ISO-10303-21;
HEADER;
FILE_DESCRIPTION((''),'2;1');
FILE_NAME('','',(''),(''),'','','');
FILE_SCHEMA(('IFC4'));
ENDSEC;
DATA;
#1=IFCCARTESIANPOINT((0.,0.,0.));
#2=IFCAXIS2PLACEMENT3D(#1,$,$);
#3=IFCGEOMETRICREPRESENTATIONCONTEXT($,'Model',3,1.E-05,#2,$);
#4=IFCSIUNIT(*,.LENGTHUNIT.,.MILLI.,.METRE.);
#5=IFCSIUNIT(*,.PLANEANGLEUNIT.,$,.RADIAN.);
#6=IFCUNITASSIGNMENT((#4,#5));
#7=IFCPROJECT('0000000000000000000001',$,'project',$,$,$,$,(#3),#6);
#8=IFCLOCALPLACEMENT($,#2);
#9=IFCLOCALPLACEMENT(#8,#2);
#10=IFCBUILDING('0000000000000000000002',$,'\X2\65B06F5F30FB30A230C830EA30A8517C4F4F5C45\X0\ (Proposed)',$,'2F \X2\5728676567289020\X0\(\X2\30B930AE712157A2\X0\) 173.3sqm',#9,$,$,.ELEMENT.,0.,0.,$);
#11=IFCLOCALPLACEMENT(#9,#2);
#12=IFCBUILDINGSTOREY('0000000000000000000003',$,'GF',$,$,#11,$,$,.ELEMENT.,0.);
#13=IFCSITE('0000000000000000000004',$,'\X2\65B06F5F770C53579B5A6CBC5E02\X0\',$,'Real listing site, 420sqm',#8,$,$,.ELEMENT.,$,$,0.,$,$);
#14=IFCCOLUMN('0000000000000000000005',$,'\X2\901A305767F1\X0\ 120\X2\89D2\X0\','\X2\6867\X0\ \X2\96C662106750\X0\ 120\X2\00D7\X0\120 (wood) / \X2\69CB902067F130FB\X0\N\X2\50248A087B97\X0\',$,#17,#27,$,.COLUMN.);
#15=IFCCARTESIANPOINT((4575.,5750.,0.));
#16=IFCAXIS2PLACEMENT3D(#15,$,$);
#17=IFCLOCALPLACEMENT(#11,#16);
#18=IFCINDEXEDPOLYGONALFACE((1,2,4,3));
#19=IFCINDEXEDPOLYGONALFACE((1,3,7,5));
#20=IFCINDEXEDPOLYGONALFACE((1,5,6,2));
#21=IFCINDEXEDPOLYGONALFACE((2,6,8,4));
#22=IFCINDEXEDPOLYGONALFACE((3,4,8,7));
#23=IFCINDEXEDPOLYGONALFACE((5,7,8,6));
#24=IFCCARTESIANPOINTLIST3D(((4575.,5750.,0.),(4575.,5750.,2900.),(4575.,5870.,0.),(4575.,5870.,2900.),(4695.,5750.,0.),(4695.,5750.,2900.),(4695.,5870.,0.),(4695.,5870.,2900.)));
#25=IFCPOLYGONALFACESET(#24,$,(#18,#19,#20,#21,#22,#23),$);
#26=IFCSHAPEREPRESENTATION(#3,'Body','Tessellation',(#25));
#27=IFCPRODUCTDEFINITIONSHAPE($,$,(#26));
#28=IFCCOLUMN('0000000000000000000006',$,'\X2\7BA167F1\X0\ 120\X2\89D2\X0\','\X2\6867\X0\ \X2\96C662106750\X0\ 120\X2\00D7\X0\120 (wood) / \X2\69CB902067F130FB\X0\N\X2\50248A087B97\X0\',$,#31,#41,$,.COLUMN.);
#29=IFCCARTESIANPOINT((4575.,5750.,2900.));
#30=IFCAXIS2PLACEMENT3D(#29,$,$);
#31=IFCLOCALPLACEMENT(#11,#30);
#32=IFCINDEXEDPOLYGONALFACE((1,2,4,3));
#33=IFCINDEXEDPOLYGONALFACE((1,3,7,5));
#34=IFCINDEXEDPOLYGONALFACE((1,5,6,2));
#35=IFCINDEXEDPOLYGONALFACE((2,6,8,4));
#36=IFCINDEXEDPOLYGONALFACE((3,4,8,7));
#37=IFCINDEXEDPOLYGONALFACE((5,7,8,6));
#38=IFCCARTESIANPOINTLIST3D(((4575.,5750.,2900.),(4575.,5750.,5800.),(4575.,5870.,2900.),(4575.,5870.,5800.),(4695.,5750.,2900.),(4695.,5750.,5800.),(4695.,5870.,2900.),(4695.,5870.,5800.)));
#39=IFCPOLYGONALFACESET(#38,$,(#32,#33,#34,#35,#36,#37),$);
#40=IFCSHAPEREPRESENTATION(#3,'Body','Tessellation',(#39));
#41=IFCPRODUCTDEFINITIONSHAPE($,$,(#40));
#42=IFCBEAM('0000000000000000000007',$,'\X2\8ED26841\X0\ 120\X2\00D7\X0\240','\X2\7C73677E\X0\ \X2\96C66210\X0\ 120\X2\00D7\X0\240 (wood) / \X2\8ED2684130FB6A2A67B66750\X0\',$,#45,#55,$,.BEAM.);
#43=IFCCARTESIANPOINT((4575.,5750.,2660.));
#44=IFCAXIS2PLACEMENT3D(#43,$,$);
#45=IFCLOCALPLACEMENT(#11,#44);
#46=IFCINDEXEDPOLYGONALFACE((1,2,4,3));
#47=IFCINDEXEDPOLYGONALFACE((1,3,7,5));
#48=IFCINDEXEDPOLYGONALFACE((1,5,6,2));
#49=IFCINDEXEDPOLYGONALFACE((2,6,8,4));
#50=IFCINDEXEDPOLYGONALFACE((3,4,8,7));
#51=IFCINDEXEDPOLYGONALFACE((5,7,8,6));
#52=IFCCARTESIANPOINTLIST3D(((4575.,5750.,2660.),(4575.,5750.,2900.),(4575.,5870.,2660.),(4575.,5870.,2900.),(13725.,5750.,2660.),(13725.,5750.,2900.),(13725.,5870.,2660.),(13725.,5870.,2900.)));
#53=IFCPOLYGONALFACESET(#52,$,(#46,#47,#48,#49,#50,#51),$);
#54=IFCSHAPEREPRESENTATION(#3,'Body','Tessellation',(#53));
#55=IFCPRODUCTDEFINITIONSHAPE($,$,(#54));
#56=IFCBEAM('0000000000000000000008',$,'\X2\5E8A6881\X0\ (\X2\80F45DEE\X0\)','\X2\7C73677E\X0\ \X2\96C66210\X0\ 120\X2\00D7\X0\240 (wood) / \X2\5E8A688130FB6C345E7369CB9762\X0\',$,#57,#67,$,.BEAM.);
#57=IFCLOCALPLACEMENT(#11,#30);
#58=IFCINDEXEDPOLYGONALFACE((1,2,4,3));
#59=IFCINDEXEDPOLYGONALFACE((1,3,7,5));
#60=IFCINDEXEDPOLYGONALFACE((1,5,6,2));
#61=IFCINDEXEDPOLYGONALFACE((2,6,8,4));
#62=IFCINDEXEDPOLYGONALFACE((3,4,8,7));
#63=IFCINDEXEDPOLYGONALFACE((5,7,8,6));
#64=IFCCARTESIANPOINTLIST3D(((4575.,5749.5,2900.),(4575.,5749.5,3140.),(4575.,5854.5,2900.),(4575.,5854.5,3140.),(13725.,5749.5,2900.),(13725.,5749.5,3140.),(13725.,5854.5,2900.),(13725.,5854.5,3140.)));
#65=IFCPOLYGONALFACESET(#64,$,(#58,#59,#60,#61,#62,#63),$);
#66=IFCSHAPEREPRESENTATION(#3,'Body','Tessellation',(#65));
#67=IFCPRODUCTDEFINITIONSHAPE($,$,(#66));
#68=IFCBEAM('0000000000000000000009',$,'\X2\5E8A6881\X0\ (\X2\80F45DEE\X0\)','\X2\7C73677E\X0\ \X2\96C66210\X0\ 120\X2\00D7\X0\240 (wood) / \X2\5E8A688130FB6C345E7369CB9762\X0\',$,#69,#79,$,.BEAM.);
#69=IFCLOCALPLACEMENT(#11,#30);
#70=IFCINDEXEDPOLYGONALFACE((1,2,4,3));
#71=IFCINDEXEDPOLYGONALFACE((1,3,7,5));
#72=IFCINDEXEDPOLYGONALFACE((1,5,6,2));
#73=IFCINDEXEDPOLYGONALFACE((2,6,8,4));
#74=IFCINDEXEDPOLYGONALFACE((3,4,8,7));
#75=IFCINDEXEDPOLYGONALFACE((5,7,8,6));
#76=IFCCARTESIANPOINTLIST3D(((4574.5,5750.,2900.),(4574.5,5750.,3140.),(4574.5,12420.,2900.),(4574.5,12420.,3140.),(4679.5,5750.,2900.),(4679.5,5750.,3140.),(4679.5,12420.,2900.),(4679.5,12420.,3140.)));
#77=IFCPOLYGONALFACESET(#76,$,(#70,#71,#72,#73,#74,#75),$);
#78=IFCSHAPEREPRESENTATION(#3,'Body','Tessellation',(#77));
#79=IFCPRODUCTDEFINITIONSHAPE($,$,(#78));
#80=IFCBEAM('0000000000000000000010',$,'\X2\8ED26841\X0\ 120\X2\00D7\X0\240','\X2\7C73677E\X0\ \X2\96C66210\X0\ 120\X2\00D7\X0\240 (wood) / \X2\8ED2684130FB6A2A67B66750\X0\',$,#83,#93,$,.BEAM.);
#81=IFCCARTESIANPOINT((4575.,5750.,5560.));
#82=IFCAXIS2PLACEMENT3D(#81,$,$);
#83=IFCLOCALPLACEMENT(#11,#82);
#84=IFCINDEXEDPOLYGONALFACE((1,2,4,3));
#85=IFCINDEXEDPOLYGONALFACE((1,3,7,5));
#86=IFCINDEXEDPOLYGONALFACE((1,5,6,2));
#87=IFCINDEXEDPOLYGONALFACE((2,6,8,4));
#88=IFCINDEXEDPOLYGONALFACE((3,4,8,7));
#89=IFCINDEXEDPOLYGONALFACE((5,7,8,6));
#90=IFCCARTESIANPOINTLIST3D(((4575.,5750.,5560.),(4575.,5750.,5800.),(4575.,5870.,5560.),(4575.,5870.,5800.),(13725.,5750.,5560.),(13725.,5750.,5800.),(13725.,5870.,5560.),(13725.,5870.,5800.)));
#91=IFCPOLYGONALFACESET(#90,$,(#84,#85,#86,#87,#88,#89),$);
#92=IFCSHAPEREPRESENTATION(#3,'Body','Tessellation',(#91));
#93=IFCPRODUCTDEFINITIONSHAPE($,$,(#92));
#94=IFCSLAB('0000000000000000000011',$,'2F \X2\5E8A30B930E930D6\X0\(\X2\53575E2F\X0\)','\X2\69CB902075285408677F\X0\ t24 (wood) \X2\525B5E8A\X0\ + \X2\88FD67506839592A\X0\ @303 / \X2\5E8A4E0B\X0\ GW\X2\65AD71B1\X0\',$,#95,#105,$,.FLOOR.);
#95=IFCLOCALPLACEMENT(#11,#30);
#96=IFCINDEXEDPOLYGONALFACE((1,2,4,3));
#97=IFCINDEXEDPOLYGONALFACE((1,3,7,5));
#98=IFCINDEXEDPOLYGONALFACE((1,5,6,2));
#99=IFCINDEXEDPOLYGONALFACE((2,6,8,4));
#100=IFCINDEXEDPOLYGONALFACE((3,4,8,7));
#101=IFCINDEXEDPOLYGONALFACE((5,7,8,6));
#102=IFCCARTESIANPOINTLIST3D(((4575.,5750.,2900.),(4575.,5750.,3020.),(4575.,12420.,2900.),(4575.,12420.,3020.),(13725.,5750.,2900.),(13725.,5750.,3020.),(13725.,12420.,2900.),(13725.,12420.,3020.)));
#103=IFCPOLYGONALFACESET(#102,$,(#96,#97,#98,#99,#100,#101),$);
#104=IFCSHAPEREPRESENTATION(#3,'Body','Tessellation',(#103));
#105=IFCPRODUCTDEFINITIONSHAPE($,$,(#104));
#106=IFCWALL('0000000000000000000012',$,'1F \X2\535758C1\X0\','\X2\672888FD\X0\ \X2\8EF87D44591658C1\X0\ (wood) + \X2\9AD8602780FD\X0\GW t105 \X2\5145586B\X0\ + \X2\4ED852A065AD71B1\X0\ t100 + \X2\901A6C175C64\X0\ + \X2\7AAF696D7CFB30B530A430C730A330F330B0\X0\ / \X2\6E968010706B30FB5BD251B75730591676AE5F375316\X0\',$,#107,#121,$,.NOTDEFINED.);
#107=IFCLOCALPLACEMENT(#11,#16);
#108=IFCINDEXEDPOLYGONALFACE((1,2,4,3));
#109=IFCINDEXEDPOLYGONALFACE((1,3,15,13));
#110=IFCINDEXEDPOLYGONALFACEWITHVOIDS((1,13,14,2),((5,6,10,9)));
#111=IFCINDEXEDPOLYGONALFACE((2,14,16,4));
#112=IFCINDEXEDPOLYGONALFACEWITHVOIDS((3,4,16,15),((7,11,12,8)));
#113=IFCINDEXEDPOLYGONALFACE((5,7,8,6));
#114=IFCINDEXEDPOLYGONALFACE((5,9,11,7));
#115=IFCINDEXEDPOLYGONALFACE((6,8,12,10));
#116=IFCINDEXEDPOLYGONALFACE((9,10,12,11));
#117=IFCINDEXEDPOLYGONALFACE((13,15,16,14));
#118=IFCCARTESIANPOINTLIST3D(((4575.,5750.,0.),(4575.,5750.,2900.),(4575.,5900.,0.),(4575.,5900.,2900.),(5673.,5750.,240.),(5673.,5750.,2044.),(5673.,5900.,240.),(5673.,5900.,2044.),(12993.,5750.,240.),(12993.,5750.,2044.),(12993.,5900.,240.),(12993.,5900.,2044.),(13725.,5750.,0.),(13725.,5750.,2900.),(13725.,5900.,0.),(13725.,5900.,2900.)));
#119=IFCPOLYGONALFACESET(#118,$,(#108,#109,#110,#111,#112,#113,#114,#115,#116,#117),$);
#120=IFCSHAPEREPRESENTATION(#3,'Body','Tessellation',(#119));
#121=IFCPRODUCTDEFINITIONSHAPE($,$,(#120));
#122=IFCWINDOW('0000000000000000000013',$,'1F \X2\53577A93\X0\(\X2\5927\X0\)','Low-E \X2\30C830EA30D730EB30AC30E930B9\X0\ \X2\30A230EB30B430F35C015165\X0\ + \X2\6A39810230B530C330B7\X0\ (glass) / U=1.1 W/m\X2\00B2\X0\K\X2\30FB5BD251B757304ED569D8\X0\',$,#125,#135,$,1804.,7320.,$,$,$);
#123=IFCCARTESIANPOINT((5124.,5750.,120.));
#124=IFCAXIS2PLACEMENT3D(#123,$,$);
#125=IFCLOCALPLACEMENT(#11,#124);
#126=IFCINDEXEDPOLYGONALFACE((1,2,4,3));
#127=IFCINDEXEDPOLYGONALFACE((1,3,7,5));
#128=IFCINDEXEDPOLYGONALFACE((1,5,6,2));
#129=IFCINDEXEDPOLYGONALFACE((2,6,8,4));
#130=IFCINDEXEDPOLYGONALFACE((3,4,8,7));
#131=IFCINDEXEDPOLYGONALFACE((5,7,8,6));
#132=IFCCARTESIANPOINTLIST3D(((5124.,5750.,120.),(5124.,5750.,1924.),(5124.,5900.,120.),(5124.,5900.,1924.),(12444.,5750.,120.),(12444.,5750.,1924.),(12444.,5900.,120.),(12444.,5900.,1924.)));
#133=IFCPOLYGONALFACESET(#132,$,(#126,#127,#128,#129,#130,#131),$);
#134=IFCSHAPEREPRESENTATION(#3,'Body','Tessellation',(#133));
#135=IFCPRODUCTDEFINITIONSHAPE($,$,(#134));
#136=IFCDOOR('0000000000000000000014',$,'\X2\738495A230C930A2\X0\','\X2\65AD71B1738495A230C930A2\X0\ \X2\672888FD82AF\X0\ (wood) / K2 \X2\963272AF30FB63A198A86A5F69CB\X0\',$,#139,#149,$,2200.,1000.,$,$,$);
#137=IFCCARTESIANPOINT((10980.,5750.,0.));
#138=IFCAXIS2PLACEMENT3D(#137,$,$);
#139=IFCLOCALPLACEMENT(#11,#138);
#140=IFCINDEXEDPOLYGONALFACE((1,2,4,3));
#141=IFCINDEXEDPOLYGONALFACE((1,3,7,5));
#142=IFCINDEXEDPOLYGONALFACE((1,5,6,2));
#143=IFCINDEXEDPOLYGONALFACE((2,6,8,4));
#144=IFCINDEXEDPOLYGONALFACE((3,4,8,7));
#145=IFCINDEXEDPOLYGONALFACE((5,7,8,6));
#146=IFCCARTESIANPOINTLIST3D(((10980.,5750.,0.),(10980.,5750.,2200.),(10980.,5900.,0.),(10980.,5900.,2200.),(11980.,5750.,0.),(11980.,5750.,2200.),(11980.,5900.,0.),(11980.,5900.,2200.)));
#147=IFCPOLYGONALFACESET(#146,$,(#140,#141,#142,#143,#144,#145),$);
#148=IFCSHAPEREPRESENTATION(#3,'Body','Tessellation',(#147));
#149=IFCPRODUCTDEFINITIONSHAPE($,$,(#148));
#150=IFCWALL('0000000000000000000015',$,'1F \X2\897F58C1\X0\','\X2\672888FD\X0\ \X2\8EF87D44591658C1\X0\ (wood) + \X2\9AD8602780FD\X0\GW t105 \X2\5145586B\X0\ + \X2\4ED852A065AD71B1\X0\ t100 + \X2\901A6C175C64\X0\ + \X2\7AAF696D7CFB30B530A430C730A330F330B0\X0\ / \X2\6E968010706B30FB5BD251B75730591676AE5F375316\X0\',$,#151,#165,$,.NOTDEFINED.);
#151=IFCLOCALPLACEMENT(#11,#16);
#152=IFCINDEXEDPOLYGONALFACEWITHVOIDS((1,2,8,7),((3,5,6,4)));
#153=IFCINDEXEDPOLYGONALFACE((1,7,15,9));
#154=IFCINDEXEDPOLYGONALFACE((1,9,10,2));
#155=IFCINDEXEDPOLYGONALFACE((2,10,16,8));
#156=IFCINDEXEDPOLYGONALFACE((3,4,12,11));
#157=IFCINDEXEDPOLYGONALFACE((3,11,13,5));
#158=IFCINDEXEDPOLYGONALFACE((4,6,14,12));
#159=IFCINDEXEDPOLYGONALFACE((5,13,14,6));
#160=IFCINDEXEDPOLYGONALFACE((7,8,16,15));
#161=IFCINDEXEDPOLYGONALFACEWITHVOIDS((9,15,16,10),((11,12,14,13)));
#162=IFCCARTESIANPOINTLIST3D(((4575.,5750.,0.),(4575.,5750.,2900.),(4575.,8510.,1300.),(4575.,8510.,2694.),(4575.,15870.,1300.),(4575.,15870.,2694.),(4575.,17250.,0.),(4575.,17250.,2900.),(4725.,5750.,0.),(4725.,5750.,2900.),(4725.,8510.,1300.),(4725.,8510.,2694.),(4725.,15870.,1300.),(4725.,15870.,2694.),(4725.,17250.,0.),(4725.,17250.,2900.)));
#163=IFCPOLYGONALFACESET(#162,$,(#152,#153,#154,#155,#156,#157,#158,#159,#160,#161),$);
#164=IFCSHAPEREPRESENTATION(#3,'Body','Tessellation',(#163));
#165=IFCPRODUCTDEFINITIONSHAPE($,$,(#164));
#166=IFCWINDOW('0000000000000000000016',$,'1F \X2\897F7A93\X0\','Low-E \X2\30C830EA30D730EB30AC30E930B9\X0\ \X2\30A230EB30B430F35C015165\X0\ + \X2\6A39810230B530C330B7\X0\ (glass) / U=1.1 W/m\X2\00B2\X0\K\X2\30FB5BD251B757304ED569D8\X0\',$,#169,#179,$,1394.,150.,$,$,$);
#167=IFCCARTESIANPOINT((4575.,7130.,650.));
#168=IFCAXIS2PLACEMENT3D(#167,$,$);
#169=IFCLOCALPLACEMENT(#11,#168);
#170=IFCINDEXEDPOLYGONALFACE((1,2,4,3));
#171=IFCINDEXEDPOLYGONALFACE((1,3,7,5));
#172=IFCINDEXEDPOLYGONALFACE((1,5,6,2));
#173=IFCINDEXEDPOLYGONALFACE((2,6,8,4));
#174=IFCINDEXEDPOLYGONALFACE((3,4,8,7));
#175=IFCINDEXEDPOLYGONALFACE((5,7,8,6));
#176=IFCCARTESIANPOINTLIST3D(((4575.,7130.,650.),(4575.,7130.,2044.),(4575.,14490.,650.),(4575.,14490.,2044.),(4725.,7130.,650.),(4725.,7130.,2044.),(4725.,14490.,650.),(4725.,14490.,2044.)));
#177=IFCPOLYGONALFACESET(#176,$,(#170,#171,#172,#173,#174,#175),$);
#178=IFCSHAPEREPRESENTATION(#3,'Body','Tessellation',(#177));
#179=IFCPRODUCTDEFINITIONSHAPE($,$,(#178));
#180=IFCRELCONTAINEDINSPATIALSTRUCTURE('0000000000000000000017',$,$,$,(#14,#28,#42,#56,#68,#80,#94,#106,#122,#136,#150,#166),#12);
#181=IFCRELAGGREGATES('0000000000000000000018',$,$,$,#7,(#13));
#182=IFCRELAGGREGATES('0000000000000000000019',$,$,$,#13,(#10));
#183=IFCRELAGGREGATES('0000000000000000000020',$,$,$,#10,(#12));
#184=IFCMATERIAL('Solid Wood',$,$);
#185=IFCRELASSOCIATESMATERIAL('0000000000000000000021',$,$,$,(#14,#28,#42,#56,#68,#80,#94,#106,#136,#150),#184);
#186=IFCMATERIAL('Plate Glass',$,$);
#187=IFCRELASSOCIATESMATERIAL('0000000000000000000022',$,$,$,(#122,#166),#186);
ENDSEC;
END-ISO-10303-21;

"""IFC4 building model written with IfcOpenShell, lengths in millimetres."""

from ifc_helpers import new_model, si_unit, frame, frame_2d, origin, place, context, project, spatial, rectangle, extrude, material, element, fill, save


model = new_model("IFC4")

# Units and contexts
model_context = context("Model", 3, precision=1e-05, world=origin())
ifc_project = project(units=[si_unit("LENGTHUNIT", "METRE", prefix="MILLI"), si_unit("PLANEANGLEUNIT", "RADIAN")], contexts=[model_context])

# Site, building, storey
site_placement = place(None, origin())
site = spatial("IfcSite", under=ifc_project, at=site_placement, Name="新潟県南魚沼市", ObjectType="Real listing site, 420sqm", CompositionType="ELEMENT", RefElevation=0.0)
building_placement = place(site_placement, origin())
building = spatial("IfcBuilding", under=site, at=building_placement, Name="新潟・アトリエ兼住居 (Proposed)", ObjectType="2F 在来木造(スギ無垢) 173.3sqm", CompositionType="ELEMENT", ElevationOfRefHeight=0.0, ElevationOfTerrain=0.0)
storey_placement = place(building_placement, origin())
storey = spatial("IfcBuildingStorey", under=building, at=storey_placement, Name="GF", CompositionType="ELEMENT", Elevation=0.0)

# Columns
ifc_material_1 = material(Name="Solid Wood")
column_1_placement = place(storey_placement, frame((4575.0, 5750.0, 0.0)))
element("IfcColumn", 1, at=column_1_placement, inside=storey, material=ifc_material_1, Name="通し柱 120角", Description="桧 集成材 120×120 (wood) / 構造柱・N値計算", PredefinedType="COLUMN", context=model_context, shape_type="SweptSolid", body=[
    extrude(rectangle(XDim=120.0, YDim=120.0, at=frame_2d((60.0, 60.0))), frame((4575.0, 5750.0, 0.0)), (0.0, 0.0, 1.0), 2900.0),
])
column_2_placement = place(storey_placement, frame((4575.0, 5750.0, 2900.0)))
element("IfcColumn", 2, at=column_2_placement, inside=storey, material=ifc_material_1, Name="管柱 120角", Description="桧 集成材 120×120 (wood) / 構造柱・N値計算", PredefinedType="COLUMN", context=model_context, shape_type="SweptSolid", body=[
    extrude(rectangle(XDim=120.0, YDim=120.0, at=frame_2d((60.0, 60.0))), frame((4575.0, 5750.0, 2900.0)), (0.0, 0.0, 1.0), 2900.0),
])

# Beams
beam_1_placement = place(storey_placement, frame((4575.0, 5750.0, 2660.0)))
element("IfcBeam", 3, at=beam_1_placement, inside=storey, material=ifc_material_1, Name="軒桁 120×240", Description="米松 集成 120×240 (wood) / 軒桁・横架材", PredefinedType="BEAM", context=model_context, shape_type="SweptSolid", body=[
    extrude(rectangle(XDim=9150.0, YDim=120.0, at=frame_2d((4575.0, 60.0))), frame((4575.0, 5750.0, 2660.0)), (0.0, 0.0, 1.0), 240.0),
])
beam_2_placement = place(storey_placement, frame((4575.0, 5750.0, 2900.0)))
element("IfcBeam", 4, at=beam_2_placement, inside=storey, material=ifc_material_1, Name="床梁 (胴差)", Description="米松 集成 120×240 (wood) / 床梁・水平構面", PredefinedType="BEAM", context=model_context, shape_type="SweptSolid", body=[
    extrude(rectangle(XDim=9150.0, YDim=105.0, at=frame_2d((4575.0, 52.0))), frame((4575.0, 5750.0, 2900.0)), (0.0, 0.0, 1.0), 240.0),
])
beam_3_placement = place(storey_placement, frame((4575.0, 5750.0, 2900.0)))
element("IfcBeam", 5, at=beam_3_placement, inside=storey, material=ifc_material_1, Name="床梁 (胴差)", Description="米松 集成 120×240 (wood) / 床梁・水平構面", PredefinedType="BEAM", context=model_context, shape_type="SweptSolid", body=[
    extrude(rectangle(XDim=105.0, YDim=6670.0, at=frame_2d((52.0, 3335.0))), frame((4575.0, 5750.0, 2900.0)), (0.0, 0.0, 1.0), 240.0),
])
beam_4_placement = place(storey_placement, frame((4575.0, 5750.0, 5560.0)))
element("IfcBeam", 6, at=beam_4_placement, inside=storey, material=ifc_material_1, Name="軒桁 120×240", Description="米松 集成 120×240 (wood) / 軒桁・横架材", PredefinedType="BEAM", context=model_context, shape_type="SweptSolid", body=[
    extrude(rectangle(XDim=9150.0, YDim=120.0, at=frame_2d((4575.0, 60.0))), frame((4575.0, 5750.0, 5560.0)), (0.0, 0.0, 1.0), 240.0),
])

# Slab
slab_1_placement = place(storey_placement, frame((4575.0, 5750.0, 2900.0)))
element("IfcSlab", 7, at=slab_1_placement, inside=storey, material=ifc_material_1, Name="2F 床スラブ(南帯)", Description="構造用合板 t24 (wood) 剛床 + 製材根太 @303 / 床下 GW断熱", PredefinedType="FLOOR", context=model_context, shape_type="SweptSolid", body=[
    extrude(rectangle(XDim=9150.0, YDim=6670.0, at=frame_2d((4575.0, 3335.0))), frame((4575.0, 5750.0, 2900.0)), (0.0, 0.0, 1.0), 120.0),
])

# Wall, openings, window, door
wall_1_placement = place(storey_placement, frame((4575.0, 5750.0, 0.0)))
wall_1 = element("IfcWall", 8, at=wall_1_placement, inside=storey, material=ifc_material_1, Name="1F 南壁", Description="木製 軸組外壁 (wood) + 高性能GW t105 充填 + 付加断熱 t100 + 通気層 + 窯業系サイディング / 準耐火・寒冷地外皮強化", PredefinedType="NOTDEFINED", context=model_context, shape_type="SweptSolid", body=[
    extrude(rectangle(XDim=9150.0, YDim=150.0, at=frame_2d((4575.0, 75.0))), frame((4575.0, 5750.0, 0.0)), (0.0, 0.0, 1.0), 2900.0),
])
opening_1_placement = place(storey_placement, frame((5124.0, 5750.0, 120.0)))
opening_1 = element("IfcOpeningElement", 9, at=opening_1_placement, cuts=wall_1, PredefinedType="NOTDEFINED", context=model_context, shape_type="SweptSolid", body=[
    extrude(rectangle(XDim=7320.0, YDim=150.0, at=frame_2d((3660.0, 75.0))), frame((5124.0, 5750.0, 120.0)), (0.0, 0.0, 1.0), 1804.0),
])
opening_2_placement = place(storey_placement, frame((10980.0, 5750.0, 0.0)))
opening_2 = element("IfcOpeningElement", 10, at=opening_2_placement, cuts=wall_1, PredefinedType="NOTDEFINED", context=model_context, shape_type="SweptSolid", body=[
    extrude(rectangle(XDim=1000.0, YDim=150.0, at=frame_2d((500.0, 75.0))), frame((10980.0, 5750.0, 0.0)), (0.0, 0.0, 1.0), 2200.0),
])
ifc_material_2 = material(Name="Plate Glass")
window_1_placement = place(storey_placement, frame((5124.0, 5750.0, 120.0)))
window_1 = element("IfcWindow", 11, at=window_1_placement, inside=storey, material=ifc_material_2, Name="1F 南窓(大)", Description="Low-E トリプルガラス アルゴン封入 + 樹脂サッシ (glass) / U=1.1 W/m²K・寒冷地仕様", OverallHeight=1804.0, OverallWidth=7320.0, context=model_context, shape_type="SweptSolid", body=[
    extrude(rectangle(XDim=7320.0, YDim=150.0, at=frame_2d((3660.0, 75.0))), frame((5124.0, 5750.0, 120.0)), (0.0, 0.0, 1.0), 1804.0),
])
fill(opening_1, window_1)
door_placement = place(storey_placement, frame((10980.0, 5750.0, 0.0)))
door = element("IfcDoor", 12, at=door_placement, inside=storey, material=ifc_material_1, Name="玄関ドア", Description="断熱玄関ドア 木製芯 (wood) / K2 防犯・採風機構", OverallHeight=2200.0, OverallWidth=1000.0, context=model_context, shape_type="SweptSolid", body=[
    extrude(rectangle(XDim=1000.0, YDim=150.0, at=frame_2d((500.0, 75.0))), frame((10980.0, 5750.0, 0.0)), (0.0, 0.0, 1.0), 2200.0),
])
fill(opening_2, door)

# Wall, opening, window
wall_2_placement = place(storey_placement, frame((4575.0, 5750.0, 0.0)))
wall_2 = element("IfcWall", 13, at=wall_2_placement, inside=storey, material=ifc_material_1, Name="1F 西壁", Description="木製 軸組外壁 (wood) + 高性能GW t105 充填 + 付加断熱 t100 + 通気層 + 窯業系サイディング / 準耐火・寒冷地外皮強化", PredefinedType="NOTDEFINED", context=model_context, shape_type="SweptSolid", body=[
    extrude(rectangle(XDim=150.0, YDim=11500.0, at=frame_2d((75.0, 5750.0))), frame((4575.0, 5750.0, 0.0)), (0.0, 0.0, 1.0), 2900.0),
])
opening_3_placement = place(storey_placement, frame((4575.0, 7130.0, 650.0)))
opening_3 = element("IfcOpeningElement", 14, at=opening_3_placement, cuts=wall_2, PredefinedType="NOTDEFINED", context=model_context, shape_type="SweptSolid", body=[
    extrude(rectangle(XDim=150.0, YDim=7360.0, at=frame_2d((75.0, 3680.0))), frame((4575.0, 7130.0, 650.0)), (0.0, 0.0, 1.0), 1394.0),
])
window_2_placement = place(storey_placement, frame((4575.0, 7130.0, 650.0)))
window_2 = element("IfcWindow", 15, at=window_2_placement, inside=storey, material=ifc_material_2, Name="1F 西窓", Description="Low-E トリプルガラス アルゴン封入 + 樹脂サッシ (glass) / U=1.1 W/m²K・寒冷地仕様", OverallHeight=1394.0, OverallWidth=150.0, context=model_context, shape_type="SweptSolid", body=[
    extrude(rectangle(XDim=150.0, YDim=7360.0, at=frame_2d((75.0, 3680.0))), frame((4575.0, 7130.0, 650.0)), (0.0, 0.0, 1.0), 1394.0),
])
fill(opening_3, window_2)

save(model, "model.ifc")
